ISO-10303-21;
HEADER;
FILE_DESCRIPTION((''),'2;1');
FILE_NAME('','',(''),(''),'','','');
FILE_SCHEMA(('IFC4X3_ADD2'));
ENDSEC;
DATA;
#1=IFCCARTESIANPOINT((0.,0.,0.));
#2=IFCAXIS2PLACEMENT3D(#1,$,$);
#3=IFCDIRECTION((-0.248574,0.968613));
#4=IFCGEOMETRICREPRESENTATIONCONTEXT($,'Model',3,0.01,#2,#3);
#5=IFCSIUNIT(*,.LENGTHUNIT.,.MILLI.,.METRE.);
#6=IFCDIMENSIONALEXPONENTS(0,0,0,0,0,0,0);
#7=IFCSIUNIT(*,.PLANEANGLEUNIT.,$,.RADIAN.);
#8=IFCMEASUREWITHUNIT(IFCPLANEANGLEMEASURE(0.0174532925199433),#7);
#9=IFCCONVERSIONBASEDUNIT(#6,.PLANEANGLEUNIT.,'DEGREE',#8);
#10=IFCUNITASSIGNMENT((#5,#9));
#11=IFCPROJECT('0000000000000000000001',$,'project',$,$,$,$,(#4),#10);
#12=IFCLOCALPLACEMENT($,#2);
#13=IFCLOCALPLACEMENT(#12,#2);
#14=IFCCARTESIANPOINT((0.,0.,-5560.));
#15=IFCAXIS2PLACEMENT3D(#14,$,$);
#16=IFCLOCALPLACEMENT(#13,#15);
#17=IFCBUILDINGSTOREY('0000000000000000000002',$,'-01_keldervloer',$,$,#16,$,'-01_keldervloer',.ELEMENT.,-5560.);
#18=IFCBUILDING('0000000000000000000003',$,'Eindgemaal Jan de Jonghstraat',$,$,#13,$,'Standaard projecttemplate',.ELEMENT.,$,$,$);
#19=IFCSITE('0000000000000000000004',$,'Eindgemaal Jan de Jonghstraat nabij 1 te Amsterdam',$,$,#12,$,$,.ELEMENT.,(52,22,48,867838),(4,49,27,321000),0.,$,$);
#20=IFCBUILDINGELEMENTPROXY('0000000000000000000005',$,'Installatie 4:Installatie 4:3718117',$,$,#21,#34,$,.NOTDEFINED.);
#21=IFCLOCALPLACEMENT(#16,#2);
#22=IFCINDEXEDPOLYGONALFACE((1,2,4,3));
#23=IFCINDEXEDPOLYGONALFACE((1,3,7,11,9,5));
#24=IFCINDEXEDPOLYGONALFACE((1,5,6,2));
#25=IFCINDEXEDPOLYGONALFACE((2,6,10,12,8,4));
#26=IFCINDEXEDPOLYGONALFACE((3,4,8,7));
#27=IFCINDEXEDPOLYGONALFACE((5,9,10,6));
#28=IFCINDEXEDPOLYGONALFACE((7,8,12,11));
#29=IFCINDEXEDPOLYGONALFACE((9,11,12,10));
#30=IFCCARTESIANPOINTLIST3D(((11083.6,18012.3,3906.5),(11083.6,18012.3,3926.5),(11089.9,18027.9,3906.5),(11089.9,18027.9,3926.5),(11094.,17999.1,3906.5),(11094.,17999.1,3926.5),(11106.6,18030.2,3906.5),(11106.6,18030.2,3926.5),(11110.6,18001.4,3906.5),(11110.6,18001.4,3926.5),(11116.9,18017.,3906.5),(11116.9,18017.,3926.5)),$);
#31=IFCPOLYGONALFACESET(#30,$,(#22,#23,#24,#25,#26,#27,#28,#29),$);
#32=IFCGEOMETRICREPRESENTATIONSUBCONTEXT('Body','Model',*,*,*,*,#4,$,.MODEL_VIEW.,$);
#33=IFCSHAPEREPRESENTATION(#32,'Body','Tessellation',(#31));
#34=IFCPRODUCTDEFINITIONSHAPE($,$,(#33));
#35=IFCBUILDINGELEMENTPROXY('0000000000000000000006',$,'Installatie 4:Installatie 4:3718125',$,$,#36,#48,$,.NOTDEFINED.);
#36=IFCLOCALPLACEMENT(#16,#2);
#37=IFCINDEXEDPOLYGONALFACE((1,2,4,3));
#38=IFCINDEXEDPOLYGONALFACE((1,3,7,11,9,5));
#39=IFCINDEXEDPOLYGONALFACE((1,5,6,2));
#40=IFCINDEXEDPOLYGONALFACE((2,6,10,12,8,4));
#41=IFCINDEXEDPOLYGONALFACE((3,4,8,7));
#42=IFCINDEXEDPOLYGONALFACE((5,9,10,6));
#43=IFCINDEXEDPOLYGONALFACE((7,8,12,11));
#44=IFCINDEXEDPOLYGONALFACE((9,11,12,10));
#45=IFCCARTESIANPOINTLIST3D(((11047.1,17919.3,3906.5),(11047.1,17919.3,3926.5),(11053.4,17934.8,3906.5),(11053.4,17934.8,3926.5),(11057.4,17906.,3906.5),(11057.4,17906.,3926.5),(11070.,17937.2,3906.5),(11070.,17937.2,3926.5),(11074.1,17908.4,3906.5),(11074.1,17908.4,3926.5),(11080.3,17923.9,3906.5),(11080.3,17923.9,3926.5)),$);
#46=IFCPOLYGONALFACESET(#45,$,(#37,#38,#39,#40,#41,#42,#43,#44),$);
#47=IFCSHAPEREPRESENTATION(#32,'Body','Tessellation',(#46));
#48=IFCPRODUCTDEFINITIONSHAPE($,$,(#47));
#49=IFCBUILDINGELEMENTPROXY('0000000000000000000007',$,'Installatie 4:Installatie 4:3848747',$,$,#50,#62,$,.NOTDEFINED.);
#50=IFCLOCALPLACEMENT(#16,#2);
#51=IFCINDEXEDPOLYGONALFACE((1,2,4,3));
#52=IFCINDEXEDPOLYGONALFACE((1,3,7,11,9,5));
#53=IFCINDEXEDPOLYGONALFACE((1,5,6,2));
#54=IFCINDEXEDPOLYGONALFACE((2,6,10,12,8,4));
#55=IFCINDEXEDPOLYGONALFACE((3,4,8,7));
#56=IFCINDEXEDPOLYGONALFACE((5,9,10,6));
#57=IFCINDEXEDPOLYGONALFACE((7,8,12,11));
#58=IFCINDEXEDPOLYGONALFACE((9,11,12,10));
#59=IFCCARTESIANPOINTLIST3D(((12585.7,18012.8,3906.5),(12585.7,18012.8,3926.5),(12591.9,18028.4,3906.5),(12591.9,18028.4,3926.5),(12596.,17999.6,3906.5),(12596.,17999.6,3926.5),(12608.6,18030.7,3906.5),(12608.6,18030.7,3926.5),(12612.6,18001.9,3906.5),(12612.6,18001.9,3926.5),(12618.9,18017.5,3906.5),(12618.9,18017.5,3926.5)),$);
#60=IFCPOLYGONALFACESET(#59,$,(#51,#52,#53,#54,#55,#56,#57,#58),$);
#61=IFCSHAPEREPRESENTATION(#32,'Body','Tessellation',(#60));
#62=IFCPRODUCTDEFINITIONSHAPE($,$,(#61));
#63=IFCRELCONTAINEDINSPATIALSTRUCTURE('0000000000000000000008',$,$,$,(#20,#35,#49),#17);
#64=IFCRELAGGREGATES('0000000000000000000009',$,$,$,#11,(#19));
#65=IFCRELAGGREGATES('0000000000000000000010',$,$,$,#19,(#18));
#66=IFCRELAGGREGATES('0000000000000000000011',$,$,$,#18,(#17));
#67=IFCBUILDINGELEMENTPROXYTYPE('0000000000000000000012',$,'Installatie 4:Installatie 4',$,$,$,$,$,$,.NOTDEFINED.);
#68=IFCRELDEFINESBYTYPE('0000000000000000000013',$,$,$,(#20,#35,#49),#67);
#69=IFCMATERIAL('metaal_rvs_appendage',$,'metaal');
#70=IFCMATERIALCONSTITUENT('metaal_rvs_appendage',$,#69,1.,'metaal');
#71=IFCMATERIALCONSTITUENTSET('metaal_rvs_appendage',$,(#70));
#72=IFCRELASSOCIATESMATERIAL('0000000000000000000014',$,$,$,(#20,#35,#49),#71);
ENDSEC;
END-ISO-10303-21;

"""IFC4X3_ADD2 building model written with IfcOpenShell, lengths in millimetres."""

from ifc_helpers import new_model, entity, si_unit, converted_unit, direction, frame, origin, place, context, subcontext, project, spatial, polyline, outline, extrude, source, transform, mapped, material, constituent, constituent_set, type_object, type_shapes, element, save


model = new_model("IFC4X3_ADD2")

# Units and contexts
model_context = context("Model", 3, precision=0.01, world=origin(), true_north=direction((-0.248574, 0.968613)))
body_context = subcontext(model_context, "Body", "Model", "MODEL_VIEW")
ifc_project = project(units=[si_unit("LENGTHUNIT", "METRE", prefix="MILLI"), converted_unit("PLANEANGLEUNIT", "DEGREE", entity("IfcPlaneAngleMeasure", 0.0174532925199433), si_unit("PLANEANGLEUNIT", "RADIAN"), dimensions=[0, 0, 0, 0, 0, 0, 0])], contexts=[model_context])

# Site, building, storey
site_placement = place(None, origin())
site = spatial("IfcSite", under=ifc_project, at=site_placement, Name="Eindgemaal Jan de Jonghstraat nabij 1 te Amsterdam", CompositionType="ELEMENT", RefLatitude=(52, 22, 48, 867838), RefLongitude=(4, 49, 27, 321000), RefElevation=0.0)
building_placement = place(site_placement, origin())
building = spatial("IfcBuilding", under=site, at=building_placement, Name="Eindgemaal Jan de Jonghstraat", LongName="Standaard projecttemplate", CompositionType="ELEMENT")
storey_placement = place(building_placement, frame((0.0, 0.0, -5560.0)))
storey = spatial("IfcBuildingStorey", under=building, at=storey_placement, Name="-01_keldervloer", LongName="-01_keldervloer", CompositionType="ELEMENT", Elevation=-5560.0)

# Building element proxies
ifc_material_1 = material(Name="metaal_rvs_appendage", Category="metaal")
ifc_constituent_1 = constituent(ifc_material_1, Name="metaal_rvs_appendage", Category="metaal", fraction=1.0)
ifc_constituent_set_1 = constituent_set(constituents=[ifc_constituent_1], Name="metaal_rvs_appendage")
building_element_proxy_type_1 = type_object("IfcBuildingElementProxyType", Name="Installatie 4:Installatie 4", PredefinedType="NOTDEFINED")
shared_shape_1 = source(origin(), body_context, "Body", "SweptSolid", [
    extrude(outline(polyline([(-8.4, -14.6), (8.4, -14.6), (16.8, 0.0), (8.4, 14.6), (-8.4, 14.6), (-16.8, 0.0), (-8.4, -14.6)])), frame((0.0, 0.0, -11.0), z_axis=(0.0, 0.0, 1.0), x_axis=(0.400458, -0.916315, 0.0)), (0.0, 0.0, 1.0), 20.0),
])
type_shapes(building_element_proxy_type_1, [shared_shape_1])
for number, where, z_axis, x_axis, name in (
    (1, (11100.3, 18014.7, 3917.5), (0.0, 0.0, 1.0), (0.968613, 0.248574, 0.0), "Installatie 4:Installatie 4:3718117"),
    (2, (11063.7, 17921.6, 3917.5), (0.0, 0.0, 1.0), (0.968613, 0.248574, 0.0), "Installatie 4:Installatie 4:3718125"),
    (3, (12602.3, 18015.2, 3917.5), (0.0, 0.0, 1.0), (0.968613, 0.248574, 0.0), "Installatie 4:Installatie 4:3848747"),
):
    element("IfcBuildingElementProxy", number, at=place(storey_placement, frame(where, z_axis=z_axis, x_axis=x_axis)), inside=storey, type_object=building_element_proxy_type_1, material=ifc_constituent_set_1, Name=name, PredefinedType="NOTDEFINED", context=body_context, shape_type="MappedRepresentation", body=[
        mapped(shared_shape_1, transform((0.0, 0.0, 0.0), scale=1.0)),
    ])

save(model, "model.ifc")
